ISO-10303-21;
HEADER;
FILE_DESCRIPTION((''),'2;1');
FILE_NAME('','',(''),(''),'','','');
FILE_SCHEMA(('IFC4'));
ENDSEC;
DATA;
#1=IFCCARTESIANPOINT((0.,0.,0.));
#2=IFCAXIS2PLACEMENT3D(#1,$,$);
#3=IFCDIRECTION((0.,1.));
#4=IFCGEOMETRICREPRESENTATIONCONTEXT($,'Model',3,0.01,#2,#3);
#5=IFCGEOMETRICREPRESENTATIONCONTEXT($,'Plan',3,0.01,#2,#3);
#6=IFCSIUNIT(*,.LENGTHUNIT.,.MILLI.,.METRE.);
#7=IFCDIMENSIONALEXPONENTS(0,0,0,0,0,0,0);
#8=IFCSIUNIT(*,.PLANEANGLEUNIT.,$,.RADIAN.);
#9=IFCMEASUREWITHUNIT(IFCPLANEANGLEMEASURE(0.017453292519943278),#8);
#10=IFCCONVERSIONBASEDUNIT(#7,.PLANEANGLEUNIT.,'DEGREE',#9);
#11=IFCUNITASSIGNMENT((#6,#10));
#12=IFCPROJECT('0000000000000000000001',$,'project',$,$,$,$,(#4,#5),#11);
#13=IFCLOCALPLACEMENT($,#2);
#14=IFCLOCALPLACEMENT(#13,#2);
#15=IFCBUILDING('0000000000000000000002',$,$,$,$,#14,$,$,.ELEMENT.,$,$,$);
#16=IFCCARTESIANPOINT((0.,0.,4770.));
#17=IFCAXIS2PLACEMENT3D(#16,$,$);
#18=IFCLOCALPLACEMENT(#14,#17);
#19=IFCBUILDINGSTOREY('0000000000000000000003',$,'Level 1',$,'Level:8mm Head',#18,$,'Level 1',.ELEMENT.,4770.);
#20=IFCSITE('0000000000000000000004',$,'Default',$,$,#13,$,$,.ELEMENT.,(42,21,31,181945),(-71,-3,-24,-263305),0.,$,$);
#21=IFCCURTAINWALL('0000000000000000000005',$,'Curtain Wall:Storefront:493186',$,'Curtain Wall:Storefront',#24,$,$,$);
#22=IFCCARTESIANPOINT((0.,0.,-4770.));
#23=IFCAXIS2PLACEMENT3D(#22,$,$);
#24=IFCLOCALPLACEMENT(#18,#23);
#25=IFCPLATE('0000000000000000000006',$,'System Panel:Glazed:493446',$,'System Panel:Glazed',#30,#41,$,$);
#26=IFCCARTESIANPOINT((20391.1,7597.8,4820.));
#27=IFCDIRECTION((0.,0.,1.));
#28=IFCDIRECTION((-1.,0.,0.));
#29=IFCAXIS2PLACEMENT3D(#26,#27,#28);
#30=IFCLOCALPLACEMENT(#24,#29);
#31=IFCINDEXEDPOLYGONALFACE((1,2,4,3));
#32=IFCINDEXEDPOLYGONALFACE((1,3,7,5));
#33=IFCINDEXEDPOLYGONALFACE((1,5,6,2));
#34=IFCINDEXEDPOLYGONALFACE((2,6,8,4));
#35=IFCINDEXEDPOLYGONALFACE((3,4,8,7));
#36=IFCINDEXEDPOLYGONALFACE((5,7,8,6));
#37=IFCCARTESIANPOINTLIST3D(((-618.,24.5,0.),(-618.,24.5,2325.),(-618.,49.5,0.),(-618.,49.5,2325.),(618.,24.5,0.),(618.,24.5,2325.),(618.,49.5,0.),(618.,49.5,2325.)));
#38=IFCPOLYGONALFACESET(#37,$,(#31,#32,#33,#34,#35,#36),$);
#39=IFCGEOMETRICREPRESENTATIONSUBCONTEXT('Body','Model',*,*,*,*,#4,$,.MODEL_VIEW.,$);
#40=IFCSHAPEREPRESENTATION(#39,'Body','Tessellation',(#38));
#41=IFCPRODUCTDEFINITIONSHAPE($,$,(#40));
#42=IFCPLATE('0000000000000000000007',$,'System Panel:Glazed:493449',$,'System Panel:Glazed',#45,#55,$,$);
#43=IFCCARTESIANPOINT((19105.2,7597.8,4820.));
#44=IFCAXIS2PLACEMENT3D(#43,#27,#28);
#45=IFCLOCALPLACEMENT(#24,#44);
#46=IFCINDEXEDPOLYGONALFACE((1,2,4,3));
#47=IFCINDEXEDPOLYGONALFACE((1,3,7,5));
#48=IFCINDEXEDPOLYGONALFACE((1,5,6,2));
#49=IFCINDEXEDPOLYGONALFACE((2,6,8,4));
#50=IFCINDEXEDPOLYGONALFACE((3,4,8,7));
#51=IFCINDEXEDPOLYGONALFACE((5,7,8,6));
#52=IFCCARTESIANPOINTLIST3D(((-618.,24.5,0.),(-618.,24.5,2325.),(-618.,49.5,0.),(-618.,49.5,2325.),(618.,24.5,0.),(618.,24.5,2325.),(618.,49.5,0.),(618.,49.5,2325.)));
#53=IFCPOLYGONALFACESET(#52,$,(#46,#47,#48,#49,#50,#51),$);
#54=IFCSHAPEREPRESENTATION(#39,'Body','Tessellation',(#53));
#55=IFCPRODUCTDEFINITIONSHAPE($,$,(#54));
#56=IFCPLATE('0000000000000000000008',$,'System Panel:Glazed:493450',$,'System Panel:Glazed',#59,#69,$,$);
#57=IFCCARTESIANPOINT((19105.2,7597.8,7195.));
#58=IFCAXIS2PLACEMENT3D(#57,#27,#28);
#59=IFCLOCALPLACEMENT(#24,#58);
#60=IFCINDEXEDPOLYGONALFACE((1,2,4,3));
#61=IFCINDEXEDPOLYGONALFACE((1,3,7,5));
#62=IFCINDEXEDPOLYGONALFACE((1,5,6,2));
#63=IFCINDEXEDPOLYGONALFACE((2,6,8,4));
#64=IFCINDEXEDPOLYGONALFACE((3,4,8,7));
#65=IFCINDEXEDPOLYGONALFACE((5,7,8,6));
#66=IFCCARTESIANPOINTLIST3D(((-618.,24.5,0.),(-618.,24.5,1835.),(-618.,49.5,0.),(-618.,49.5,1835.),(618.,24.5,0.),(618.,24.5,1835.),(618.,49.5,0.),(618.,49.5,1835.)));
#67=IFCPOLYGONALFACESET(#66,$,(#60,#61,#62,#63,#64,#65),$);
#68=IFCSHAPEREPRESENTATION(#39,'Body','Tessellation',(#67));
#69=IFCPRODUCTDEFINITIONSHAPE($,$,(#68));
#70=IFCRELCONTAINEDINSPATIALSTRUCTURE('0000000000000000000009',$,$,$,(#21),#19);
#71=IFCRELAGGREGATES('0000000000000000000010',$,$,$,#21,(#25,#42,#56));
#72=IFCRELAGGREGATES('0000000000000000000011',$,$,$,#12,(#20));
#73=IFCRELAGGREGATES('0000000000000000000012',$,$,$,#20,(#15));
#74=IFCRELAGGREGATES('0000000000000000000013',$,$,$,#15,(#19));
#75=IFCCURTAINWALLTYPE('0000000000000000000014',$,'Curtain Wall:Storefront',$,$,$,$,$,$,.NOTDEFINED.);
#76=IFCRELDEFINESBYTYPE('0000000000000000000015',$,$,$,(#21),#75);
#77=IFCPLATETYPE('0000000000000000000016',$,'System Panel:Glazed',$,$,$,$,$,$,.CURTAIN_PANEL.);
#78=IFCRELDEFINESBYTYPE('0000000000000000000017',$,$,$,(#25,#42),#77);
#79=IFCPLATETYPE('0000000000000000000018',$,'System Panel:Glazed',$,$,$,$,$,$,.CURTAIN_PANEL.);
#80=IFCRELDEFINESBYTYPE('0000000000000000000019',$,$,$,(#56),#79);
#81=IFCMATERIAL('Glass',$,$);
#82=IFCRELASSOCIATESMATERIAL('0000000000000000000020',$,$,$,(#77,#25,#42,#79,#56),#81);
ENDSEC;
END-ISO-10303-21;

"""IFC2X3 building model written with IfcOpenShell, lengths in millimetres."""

from ifc_helpers import new_model, entity, si_unit, converted_unit, direction, frame, origin, origin_2d_with_axis, place, context, subcontext, project, spatial, rectangle, extrude, source, transform, mapped, material, type_object, type_shapes, element, aggregate, save


model = new_model("IFC2X3")

# Units and contexts
model_context = context("Model", 3, precision=0.01, world=origin(), true_north=direction((0.0, 1.0)))
plan_context = context("Plan", 3, precision=0.01, world=origin(), true_north=direction((0.0, 1.0)))
body_context = subcontext(model_context, "Body", "Model", "MODEL_VIEW")
ifc_project = project(units=[si_unit("LENGTHUNIT", "METRE", prefix="MILLI"), converted_unit("PLANEANGLEUNIT", "DEGREE", entity("IfcPlaneAngleMeasure", 0.017453292519943278), si_unit("PLANEANGLEUNIT", "RADIAN"), dimensions=[0, 0, 0, 0, 0, 0, 0])], contexts=[model_context, plan_context])

# Site, building, storey
site_placement = place(None, origin())
site = spatial("IfcSite", under=ifc_project, at=site_placement, Name="Default", CompositionType="ELEMENT", RefLatitude=(42, 21, 31, 181945), RefLongitude=(-71, -3, -24, -263305), RefElevation=0.0)
building_placement = place(site_placement, origin())
building = spatial("IfcBuilding", under=site, at=building_placement, CompositionType="ELEMENT")
storey_placement = place(building_placement, frame((0.0, 0.0, 4770.0)))
storey = spatial("IfcBuildingStorey", under=building, at=storey_placement, Name="Level 1", ObjectType="Level:8mm Head", LongName="Level 1", CompositionType="ELEMENT", Elevation=4770.0)

# Curtain wall
curtain_wall_type = type_object("IfcCurtainWallType", Name="Curtain Wall:Storefront", PredefinedType="NOTDEFINED")
curtain_wall_1_placement = place(storey_placement, frame((0.0, 0.0, -4770.0)))
curtain_wall_1 = element("IfcCurtainWall", 1, at=curtain_wall_1_placement, inside=storey, type_object=curtain_wall_type, Name="Curtain Wall:Storefront:493186", ObjectType="Curtain Wall:Storefront")

# Plates
ifc_material_1 = material(Name="Glass")
plate_type_1 = type_object("IfcPlateType", Name="System Panel:Glazed", PredefinedType="CURTAIN_PANEL", material=ifc_material_1)
shared_shape_1 = source(origin(), body_context, "Body", "SweptSolid", [
    extrude(rectangle(XDim=25.0, YDim=1236.0, at=origin_2d_with_axis()), frame((0.0, 37.0, 0.0), z_axis=(0.0, 0.0, 1.0), x_axis=(0.0, 1.0, 0.0)), (0.0, 0.0, 1.0), 2325.0),
])
type_shapes(plate_type_1, [shared_shape_1])
plate_1_placement = place(curtain_wall_1_placement, frame((20391.1, 7597.8, 4820.0), z_axis=(0.0, 0.0, 1.0), x_axis=(-1.0, 0.0, 0.0)))
plate_1 = element("IfcPlate", 2, at=plate_1_placement, type_object=plate_type_1, material=ifc_material_1, Name="System Panel:Glazed:493446", ObjectType="System Panel:Glazed", context=body_context, shape_type="MappedRepresentation", body=[
    mapped(shared_shape_1, transform((0.0, 0.0, 0.0), scale=1.0)),
])
plate_2_placement = place(curtain_wall_1_placement, frame((19105.2, 7597.8, 4820.0), z_axis=(0.0, 0.0, 1.0), x_axis=(-1.0, 0.0, 0.0)))
plate_2 = element("IfcPlate", 3, at=plate_2_placement, type_object=plate_type_1, material=ifc_material_1, Name="System Panel:Glazed:493449", ObjectType="System Panel:Glazed", context=body_context, shape_type="MappedRepresentation", body=[
    mapped(shared_shape_1, transform((0.0, 0.0, 0.0), scale=1.0)),
])
plate_type_2 = type_object("IfcPlateType", Name="System Panel:Glazed", PredefinedType="CURTAIN_PANEL", material=ifc_material_1)
shared_shape_2 = source(origin(), body_context, "Body", "SweptSolid", [
    extrude(rectangle(XDim=25.0, YDim=1236.0, at=origin_2d_with_axis()), frame((0.0, 37.0, 0.0), z_axis=(0.0, 0.0, 1.0), x_axis=(0.0, 1.0, 0.0)), (0.0, 0.0, 1.0), 1835.0),
])
type_shapes(plate_type_2, [shared_shape_2])
plate_3_placement = place(curtain_wall_1_placement, frame((19105.2, 7597.8, 7195.0), z_axis=(0.0, 0.0, 1.0), x_axis=(-1.0, 0.0, 0.0)))
plate_3 = element("IfcPlate", 4, at=plate_3_placement, type_object=plate_type_2, material=ifc_material_1, Name="System Panel:Glazed:493450", ObjectType="System Panel:Glazed", context=body_context, shape_type="MappedRepresentation", body=[
    mapped(shared_shape_2, transform((0.0, 0.0, 0.0), scale=1.0)),
])
aggregate(curtain_wall_1, [plate_1, plate_2, plate_3])

save(model, "model.ifc")
